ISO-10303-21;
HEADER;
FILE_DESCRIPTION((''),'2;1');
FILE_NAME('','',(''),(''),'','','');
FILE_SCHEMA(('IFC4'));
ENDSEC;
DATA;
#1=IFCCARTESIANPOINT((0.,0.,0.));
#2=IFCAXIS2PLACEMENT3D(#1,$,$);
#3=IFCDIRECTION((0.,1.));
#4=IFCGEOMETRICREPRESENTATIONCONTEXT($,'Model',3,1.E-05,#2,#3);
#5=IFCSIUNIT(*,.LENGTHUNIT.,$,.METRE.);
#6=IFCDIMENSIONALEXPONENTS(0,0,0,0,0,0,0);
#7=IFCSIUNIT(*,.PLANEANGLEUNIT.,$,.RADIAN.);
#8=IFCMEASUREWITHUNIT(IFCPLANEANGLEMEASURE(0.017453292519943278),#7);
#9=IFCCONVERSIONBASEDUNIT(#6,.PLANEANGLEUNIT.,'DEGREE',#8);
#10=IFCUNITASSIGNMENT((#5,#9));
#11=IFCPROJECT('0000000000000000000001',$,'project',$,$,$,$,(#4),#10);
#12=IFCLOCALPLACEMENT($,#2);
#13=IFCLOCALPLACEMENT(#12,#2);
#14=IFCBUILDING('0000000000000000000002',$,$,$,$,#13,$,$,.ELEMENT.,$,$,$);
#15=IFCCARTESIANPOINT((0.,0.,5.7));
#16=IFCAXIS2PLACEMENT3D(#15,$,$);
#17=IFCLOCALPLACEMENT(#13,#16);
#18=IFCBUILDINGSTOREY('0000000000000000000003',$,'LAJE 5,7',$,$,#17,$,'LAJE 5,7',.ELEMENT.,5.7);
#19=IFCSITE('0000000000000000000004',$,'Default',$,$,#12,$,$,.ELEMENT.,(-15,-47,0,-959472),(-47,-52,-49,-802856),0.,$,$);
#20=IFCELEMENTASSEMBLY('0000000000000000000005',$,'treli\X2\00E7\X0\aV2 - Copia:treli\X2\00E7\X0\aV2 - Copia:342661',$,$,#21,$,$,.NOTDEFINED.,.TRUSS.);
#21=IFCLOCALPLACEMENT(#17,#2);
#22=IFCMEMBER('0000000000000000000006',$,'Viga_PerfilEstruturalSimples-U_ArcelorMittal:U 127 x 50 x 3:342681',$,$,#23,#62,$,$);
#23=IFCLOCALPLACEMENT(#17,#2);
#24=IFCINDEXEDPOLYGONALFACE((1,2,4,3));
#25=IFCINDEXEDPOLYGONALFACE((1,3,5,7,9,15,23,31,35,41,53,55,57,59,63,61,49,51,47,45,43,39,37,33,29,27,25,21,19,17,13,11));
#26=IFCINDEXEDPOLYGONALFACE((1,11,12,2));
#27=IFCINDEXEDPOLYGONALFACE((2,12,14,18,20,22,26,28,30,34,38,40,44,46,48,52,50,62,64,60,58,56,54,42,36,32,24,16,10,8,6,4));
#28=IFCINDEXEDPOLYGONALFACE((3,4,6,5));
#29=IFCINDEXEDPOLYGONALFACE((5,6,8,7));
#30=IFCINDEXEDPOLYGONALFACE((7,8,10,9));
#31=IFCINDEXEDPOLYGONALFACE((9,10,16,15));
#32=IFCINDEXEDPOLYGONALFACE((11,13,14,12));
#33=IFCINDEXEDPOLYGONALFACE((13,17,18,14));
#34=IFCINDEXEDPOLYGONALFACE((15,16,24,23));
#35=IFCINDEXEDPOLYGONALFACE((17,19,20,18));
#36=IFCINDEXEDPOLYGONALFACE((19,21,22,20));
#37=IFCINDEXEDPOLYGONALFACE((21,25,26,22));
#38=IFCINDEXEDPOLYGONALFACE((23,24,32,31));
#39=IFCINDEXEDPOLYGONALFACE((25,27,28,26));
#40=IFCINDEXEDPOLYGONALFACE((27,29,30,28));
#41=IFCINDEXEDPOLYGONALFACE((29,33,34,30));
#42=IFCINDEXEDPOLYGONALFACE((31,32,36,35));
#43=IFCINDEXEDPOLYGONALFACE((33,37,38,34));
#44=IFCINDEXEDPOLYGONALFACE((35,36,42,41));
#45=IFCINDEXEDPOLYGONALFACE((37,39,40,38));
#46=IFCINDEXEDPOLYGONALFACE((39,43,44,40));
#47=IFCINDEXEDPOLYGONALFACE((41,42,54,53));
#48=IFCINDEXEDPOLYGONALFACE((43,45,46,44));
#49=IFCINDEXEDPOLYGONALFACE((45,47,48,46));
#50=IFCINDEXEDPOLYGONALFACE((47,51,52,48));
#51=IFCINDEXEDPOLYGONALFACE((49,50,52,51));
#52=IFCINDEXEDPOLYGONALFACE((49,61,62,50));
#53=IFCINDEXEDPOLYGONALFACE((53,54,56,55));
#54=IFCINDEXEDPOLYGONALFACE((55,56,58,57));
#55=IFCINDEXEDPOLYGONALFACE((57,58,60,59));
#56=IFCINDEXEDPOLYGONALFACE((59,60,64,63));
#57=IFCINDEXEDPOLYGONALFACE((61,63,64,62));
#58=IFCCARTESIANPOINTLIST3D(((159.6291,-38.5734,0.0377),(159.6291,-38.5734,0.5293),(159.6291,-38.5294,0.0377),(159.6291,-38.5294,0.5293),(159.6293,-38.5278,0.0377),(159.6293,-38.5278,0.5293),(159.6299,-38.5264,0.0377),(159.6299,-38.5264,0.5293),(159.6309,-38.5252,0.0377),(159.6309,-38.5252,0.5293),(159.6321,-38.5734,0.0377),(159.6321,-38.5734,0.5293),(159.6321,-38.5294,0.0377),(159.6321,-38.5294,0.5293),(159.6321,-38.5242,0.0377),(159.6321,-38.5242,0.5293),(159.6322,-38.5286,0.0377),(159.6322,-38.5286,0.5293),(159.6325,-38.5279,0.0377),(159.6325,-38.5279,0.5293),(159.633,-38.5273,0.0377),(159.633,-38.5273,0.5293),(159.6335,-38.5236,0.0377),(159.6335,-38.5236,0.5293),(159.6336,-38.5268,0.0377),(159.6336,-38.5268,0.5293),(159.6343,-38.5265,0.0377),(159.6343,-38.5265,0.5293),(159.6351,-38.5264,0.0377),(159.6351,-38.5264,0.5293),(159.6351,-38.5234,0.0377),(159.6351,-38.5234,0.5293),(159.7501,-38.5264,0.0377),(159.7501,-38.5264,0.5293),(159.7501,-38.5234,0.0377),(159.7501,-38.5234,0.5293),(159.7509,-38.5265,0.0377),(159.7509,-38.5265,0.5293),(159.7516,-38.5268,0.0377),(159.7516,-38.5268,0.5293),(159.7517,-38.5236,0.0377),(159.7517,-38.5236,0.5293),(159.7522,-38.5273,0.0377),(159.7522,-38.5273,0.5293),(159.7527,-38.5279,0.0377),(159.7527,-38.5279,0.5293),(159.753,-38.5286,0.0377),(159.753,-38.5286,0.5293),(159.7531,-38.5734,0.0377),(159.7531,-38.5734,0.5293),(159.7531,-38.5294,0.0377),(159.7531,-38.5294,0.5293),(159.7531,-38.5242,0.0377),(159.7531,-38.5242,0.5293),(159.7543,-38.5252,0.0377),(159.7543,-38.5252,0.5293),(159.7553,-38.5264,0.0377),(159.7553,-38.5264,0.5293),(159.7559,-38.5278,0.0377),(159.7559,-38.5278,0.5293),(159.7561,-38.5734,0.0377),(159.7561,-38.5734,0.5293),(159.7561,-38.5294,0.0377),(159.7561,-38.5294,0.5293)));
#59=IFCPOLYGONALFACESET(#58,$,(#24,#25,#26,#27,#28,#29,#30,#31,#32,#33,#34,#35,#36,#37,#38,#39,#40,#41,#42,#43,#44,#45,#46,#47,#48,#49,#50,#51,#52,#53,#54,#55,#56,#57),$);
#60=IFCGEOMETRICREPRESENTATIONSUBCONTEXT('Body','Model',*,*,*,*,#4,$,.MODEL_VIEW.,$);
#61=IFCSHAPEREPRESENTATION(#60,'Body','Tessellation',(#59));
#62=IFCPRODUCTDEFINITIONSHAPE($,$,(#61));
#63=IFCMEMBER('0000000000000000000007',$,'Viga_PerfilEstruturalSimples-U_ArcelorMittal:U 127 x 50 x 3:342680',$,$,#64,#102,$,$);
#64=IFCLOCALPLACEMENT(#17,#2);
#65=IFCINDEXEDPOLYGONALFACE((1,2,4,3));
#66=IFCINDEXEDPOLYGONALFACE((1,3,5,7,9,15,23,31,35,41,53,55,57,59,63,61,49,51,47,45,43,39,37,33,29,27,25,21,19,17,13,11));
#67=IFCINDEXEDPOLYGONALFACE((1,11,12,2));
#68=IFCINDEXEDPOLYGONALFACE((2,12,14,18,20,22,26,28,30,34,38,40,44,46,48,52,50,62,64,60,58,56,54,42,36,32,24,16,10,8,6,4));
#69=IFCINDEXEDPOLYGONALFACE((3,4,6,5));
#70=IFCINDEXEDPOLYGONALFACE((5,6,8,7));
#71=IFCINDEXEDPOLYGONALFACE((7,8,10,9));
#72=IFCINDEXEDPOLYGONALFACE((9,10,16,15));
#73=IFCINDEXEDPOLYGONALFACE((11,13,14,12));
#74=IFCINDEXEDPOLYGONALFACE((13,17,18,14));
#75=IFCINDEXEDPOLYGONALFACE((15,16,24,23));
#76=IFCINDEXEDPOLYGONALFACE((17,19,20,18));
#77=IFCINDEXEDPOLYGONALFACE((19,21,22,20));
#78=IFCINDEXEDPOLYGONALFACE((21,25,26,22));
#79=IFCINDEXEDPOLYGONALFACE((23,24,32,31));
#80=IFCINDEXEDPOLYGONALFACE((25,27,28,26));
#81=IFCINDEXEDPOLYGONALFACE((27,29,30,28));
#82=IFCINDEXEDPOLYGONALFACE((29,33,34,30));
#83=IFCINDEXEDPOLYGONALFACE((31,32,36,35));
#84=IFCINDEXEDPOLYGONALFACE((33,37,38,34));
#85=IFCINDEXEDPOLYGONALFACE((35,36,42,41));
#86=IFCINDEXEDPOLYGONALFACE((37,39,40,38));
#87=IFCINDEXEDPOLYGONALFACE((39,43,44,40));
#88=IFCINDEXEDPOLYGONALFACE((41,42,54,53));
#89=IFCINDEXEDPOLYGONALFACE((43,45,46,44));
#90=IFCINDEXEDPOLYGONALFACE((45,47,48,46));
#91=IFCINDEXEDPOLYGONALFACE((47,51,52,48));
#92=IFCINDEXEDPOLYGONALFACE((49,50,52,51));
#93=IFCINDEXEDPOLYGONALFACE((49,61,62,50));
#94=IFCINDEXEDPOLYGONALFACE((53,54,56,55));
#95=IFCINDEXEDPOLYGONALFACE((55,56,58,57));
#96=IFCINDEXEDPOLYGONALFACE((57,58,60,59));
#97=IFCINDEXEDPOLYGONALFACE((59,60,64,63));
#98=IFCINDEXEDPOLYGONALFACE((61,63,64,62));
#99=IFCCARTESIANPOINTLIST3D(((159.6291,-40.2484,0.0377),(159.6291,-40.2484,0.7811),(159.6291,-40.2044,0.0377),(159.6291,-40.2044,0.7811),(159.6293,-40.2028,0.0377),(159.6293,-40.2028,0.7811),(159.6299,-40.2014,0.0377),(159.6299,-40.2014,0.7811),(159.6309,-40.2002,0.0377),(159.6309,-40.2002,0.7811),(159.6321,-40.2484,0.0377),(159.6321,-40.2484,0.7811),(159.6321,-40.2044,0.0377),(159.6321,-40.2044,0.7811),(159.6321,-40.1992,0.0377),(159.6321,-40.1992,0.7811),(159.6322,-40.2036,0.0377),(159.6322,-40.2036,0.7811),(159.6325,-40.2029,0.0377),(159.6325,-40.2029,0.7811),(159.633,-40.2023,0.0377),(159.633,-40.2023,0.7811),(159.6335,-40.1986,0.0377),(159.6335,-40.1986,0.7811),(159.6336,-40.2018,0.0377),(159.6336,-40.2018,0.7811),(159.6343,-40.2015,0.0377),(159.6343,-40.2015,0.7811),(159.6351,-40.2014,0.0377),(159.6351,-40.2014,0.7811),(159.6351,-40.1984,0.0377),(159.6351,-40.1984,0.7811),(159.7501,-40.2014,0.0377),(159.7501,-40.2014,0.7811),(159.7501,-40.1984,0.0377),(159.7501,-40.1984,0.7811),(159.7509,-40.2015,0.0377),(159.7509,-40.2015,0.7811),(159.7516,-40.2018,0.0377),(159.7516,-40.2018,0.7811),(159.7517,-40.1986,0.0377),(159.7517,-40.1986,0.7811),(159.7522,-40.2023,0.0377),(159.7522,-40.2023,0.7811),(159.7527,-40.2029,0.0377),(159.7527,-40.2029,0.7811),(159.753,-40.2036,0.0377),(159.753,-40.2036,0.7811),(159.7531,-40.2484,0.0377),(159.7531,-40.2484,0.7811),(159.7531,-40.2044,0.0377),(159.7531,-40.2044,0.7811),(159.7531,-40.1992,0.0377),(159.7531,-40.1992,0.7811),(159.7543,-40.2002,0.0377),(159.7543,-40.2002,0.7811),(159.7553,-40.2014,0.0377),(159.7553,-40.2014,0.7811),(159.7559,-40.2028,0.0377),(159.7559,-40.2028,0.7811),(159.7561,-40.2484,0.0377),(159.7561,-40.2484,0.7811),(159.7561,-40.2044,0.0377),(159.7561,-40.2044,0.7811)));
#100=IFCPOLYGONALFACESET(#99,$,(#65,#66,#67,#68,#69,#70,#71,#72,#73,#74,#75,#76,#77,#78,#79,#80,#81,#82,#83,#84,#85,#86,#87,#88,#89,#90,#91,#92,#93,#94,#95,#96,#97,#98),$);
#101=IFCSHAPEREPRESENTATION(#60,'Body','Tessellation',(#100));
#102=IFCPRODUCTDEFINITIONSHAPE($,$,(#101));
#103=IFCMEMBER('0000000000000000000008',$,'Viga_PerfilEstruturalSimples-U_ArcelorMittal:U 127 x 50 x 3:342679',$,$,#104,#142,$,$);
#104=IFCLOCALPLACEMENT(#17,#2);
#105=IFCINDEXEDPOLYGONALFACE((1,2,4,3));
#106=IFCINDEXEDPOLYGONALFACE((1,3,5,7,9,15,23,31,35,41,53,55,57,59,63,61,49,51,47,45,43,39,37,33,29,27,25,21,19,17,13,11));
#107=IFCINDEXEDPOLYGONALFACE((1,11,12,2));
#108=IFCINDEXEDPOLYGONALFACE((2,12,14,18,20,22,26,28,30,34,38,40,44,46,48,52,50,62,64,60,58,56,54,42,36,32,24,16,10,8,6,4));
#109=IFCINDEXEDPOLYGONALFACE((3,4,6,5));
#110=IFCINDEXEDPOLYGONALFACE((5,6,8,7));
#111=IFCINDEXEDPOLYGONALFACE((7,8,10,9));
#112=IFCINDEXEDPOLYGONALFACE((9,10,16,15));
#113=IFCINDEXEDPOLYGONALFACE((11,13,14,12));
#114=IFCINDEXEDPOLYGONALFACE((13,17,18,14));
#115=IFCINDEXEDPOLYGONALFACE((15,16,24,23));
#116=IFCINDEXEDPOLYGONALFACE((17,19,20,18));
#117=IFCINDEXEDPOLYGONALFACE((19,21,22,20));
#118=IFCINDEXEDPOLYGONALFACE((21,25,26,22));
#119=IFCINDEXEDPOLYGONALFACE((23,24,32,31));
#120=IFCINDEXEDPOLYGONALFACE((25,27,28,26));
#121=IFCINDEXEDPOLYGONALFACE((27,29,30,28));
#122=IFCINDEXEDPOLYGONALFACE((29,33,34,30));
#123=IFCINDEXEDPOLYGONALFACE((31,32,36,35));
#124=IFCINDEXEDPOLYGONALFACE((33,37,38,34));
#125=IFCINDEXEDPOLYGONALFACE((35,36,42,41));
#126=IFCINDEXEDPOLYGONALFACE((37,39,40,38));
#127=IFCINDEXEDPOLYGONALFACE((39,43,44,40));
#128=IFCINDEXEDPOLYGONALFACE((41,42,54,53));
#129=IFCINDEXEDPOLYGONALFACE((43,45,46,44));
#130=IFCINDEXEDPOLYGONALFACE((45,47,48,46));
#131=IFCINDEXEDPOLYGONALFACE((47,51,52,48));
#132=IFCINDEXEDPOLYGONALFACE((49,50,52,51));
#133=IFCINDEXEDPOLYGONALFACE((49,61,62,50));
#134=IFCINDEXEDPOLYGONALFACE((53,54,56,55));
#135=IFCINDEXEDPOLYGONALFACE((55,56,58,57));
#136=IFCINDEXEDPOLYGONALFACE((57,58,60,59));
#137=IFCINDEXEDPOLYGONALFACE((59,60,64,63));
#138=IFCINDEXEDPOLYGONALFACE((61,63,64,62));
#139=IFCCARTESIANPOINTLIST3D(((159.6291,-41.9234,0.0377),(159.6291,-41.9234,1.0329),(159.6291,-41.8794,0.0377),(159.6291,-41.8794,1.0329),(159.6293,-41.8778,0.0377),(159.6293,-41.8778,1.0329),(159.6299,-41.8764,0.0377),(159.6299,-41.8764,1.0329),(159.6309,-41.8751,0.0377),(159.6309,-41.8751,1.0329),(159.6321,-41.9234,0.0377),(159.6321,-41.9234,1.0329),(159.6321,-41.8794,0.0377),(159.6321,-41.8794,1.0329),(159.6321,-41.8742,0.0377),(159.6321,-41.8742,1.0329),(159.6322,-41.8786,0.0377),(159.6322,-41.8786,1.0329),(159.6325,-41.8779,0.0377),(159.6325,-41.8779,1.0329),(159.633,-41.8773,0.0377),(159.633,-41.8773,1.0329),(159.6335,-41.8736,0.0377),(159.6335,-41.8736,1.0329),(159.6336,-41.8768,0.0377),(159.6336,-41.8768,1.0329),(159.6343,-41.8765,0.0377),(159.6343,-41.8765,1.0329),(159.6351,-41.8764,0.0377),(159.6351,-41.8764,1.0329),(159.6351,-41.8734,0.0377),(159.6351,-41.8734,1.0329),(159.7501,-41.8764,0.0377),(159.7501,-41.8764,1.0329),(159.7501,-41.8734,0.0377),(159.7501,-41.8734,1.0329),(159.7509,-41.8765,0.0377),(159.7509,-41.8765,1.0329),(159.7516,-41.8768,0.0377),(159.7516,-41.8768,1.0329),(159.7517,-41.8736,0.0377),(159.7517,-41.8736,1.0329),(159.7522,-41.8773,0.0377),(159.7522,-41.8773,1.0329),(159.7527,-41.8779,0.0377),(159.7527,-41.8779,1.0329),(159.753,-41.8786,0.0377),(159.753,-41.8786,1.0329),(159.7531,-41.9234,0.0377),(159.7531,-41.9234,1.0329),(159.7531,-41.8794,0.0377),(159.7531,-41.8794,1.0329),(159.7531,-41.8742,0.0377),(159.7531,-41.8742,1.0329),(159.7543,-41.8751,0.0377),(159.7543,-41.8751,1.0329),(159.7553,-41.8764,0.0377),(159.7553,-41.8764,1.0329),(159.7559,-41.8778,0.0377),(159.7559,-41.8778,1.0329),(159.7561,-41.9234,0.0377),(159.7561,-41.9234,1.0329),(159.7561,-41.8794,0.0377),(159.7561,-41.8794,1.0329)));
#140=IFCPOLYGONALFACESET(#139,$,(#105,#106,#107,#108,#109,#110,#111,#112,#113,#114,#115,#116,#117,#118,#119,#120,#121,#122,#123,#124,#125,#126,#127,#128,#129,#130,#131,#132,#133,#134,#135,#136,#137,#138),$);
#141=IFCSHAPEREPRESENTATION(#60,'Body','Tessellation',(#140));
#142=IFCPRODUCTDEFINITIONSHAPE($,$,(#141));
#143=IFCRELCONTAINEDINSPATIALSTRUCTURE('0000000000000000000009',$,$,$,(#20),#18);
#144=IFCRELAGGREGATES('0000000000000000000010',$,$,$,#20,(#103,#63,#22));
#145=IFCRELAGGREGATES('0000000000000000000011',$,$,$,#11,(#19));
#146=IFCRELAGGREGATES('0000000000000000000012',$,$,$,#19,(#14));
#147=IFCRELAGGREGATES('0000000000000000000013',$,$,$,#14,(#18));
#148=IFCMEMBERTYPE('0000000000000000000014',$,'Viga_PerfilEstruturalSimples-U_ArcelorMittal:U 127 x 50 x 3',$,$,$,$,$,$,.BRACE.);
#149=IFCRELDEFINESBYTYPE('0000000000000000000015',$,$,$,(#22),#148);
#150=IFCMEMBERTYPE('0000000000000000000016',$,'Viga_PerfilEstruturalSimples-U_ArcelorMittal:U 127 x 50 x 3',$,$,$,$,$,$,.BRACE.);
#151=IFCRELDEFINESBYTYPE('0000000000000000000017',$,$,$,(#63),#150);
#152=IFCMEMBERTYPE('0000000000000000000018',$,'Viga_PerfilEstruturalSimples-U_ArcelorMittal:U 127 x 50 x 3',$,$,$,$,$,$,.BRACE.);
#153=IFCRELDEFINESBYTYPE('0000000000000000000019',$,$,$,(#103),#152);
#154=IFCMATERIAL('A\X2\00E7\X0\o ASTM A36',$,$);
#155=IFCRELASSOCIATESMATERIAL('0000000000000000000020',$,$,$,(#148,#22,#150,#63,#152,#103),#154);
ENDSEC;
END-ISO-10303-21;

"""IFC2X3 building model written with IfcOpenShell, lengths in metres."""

from ifc_helpers import new_model, entity, si_unit, converted_unit, direction, frame, frame_2d, origin, place, context, subcontext, project, spatial, polyline, circle_curve, parameter, trimmed, segment, composite_curve, outline, extrude, source, transform, mapped, material, type_object, type_shapes, element, aggregate, save


model = new_model("IFC2X3")

# Units and contexts
model_context = context("Model", 3, precision=1e-05, world=origin(), true_north=direction((0.0, 1.0)))
body_context = subcontext(model_context, "Body", "Model", "MODEL_VIEW")
ifc_project = project(units=[si_unit("LENGTHUNIT", "METRE"), converted_unit("PLANEANGLEUNIT", "DEGREE", entity("IfcPlaneAngleMeasure", 0.017453292519943278), si_unit("PLANEANGLEUNIT", "RADIAN"), dimensions=[0, 0, 0, 0, 0, 0, 0])], contexts=[model_context])

# Site, building, storey
site_placement = place(None, origin())
site = spatial("IfcSite", under=ifc_project, at=site_placement, Name="Default", CompositionType="ELEMENT", RefLatitude=(-15, -47, 0, -959472), RefLongitude=(-47, -52, -49, -802856), RefElevation=0.0)
building_placement = place(site_placement, origin())
building = spatial("IfcBuilding", under=site, at=building_placement, CompositionType="ELEMENT")
storey_placement = place(building_placement, frame((0.0, 0.0, 5.7)))
storey = spatial("IfcBuildingStorey", under=building, at=storey_placement, Name="LAJE 5,7", LongName="LAJE 5,7", CompositionType="ELEMENT", Elevation=5.7)

# Element assembly
ifc_material = material(Name="Aço ASTM A36")
assembly_1_placement = place(storey_placement, origin())
assembly_1 = element("IfcElementAssembly", 1, at=assembly_1_placement, inside=storey, Name="treliçaV2 - Copia:treliçaV2 - Copia:342661", AssemblyPlace="NOTDEFINED", PredefinedType="TRUSS")

# Members
member_type_1 = type_object("IfcMemberType", Name="Viga_PerfilEstruturalSimples-U_ArcelorMittal:U 127 x 50 x 3", PredefinedType="BRACE", material=ifc_material)
shared_shape_1 = source(origin(), body_context, "Body", "SweptSolid", [
    extrude(outline(composite_curve([segment(polyline([(-0.0575, -0.0192), (0.0575, -0.0192)]), True, "CONTINUOUS"), segment(trimmed(circle_curve(frame_2d((0.0575, -0.0132), x_axis=(0.0, 1.0)), 0.006), [parameter(180.0)], [parameter(270.0)], True, "PARAMETER"), True, "CONTINUOUS"), segment(polyline([(0.0635, -0.0132), (0.0635, 0.0308)]), True, "CONTINUOUS"), segment(polyline([(0.0635, 0.0308), (0.0605, 0.0308)]), True, "CONTINUOUS"), segment(polyline([(0.0605, 0.0308), (0.0605, -0.0132)]), True, "CONTINUOUS"), segment(trimmed(circle_curve(frame_2d((0.0575, -0.0132), x_axis=(0.0, 1.0)), 0.003), [parameter(180.0)], [parameter(270.0)], True, "PARAMETER"), False, "CONTINUOUS"), segment(polyline([(0.0575, -0.0162), (-0.0575, -0.0162)]), True, "CONTINUOUS"), segment(trimmed(circle_curve(frame_2d((-0.0575, -0.0132), x_axis=(0.0, 1.0)), 0.003), [parameter(90.0)], [parameter(180.0)], True, "PARAMETER"), False, "CONTINUOUS"), segment(polyline([(-0.0605, -0.0132), (-0.0605, 0.0308)]), True, "CONTINUOUS"), segment(polyline([(-0.0605, 0.0308), (-0.0635, 0.0308)]), True, "CONTINUOUS"), segment(polyline([(-0.0635, 0.0308), (-0.0635, -0.0132)]), True, "CONTINUOUS"), segment(trimmed(circle_curve(frame_2d((-0.0575, -0.0132), x_axis=(0.0, 1.0)), 0.006), [parameter(90.0)], [parameter(180.0)], True, "PARAMETER"), True, "CONTINUOUS")], self_intersect=False)), frame((-0.2478, -0.0058, 0.0), z_axis=(1.0, 0.0, 0.0), x_axis=(0.0, 0.0, -1.0)), (0.0, 0.0, 1.0), 0.4916),
])
type_shapes(member_type_1, [shared_shape_1])
member_1_placement = place(assembly_1_placement, frame((159.6926, -38.5484, 0.2855), z_axis=(1.0, 0.0, 0.0), x_axis=(0.0, 0.0, 1.0)))
member_1 = element("IfcMember", 2, at=member_1_placement, type_object=member_type_1, material=ifc_material, Name="Viga_PerfilEstruturalSimples-U_ArcelorMittal:U 127 x 50 x 3:342681", context=body_context, shape_type="MappedRepresentation", body=[
    mapped(shared_shape_1, transform((0.0, 0.0, 0.0), scale=1.0)),
])
member_type_2 = type_object("IfcMemberType", Name="Viga_PerfilEstruturalSimples-U_ArcelorMittal:U 127 x 50 x 3", PredefinedType="BRACE", material=ifc_material)
shared_shape_2 = source(origin(), body_context, "Body", "SweptSolid", [
    extrude(outline(composite_curve([segment(polyline([(-0.0575, -0.0192), (0.0575, -0.0192)]), True, "CONTINUOUS"), segment(trimmed(circle_curve(frame_2d((0.0575, -0.0132), x_axis=(0.0, 1.0)), 0.006), [parameter(180.0)], [parameter(270.0)], True, "PARAMETER"), True, "CONTINUOUS"), segment(polyline([(0.0635, -0.0132), (0.0635, 0.0308)]), True, "CONTINUOUS"), segment(polyline([(0.0635, 0.0308), (0.0605, 0.0308)]), True, "CONTINUOUS"), segment(polyline([(0.0605, 0.0308), (0.0605, -0.0132)]), True, "CONTINUOUS"), segment(trimmed(circle_curve(frame_2d((0.0575, -0.0132), x_axis=(0.0, 1.0)), 0.003), [parameter(180.0)], [parameter(270.0)], True, "PARAMETER"), False, "CONTINUOUS"), segment(polyline([(0.0575, -0.0162), (-0.0575, -0.0162)]), True, "CONTINUOUS"), segment(trimmed(circle_curve(frame_2d((-0.0575, -0.0132), x_axis=(0.0, 1.0)), 0.003), [parameter(90.0)], [parameter(180.0)], True, "PARAMETER"), False, "CONTINUOUS"), segment(polyline([(-0.0605, -0.0132), (-0.0605, 0.0308)]), True, "CONTINUOUS"), segment(polyline([(-0.0605, 0.0308), (-0.0635, 0.0308)]), True, "CONTINUOUS"), segment(polyline([(-0.0635, 0.0308), (-0.0635, -0.0132)]), True, "CONTINUOUS"), segment(trimmed(circle_curve(frame_2d((-0.0575, -0.0132), x_axis=(0.0, 1.0)), 0.006), [parameter(90.0)], [parameter(180.0)], True, "PARAMETER"), True, "CONTINUOUS")], self_intersect=False)), frame((-0.3737, -0.0058, 0.0), z_axis=(1.0, 0.0, 0.0), x_axis=(0.0, 0.0, -1.0)), (0.0, 0.0, 1.0), 0.7434),
])
type_shapes(member_type_2, [shared_shape_2])
member_2_placement = place(assembly_1_placement, frame((159.6926, -40.2234, 0.4114), z_axis=(1.0, 0.0, 0.0), x_axis=(0.0, 0.0, 1.0)))
member_2 = element("IfcMember", 3, at=member_2_placement, type_object=member_type_2, material=ifc_material, Name="Viga_PerfilEstruturalSimples-U_ArcelorMittal:U 127 x 50 x 3:342680", context=body_context, shape_type="MappedRepresentation", body=[
    mapped(shared_shape_2, transform((0.0, 0.0, 0.0), scale=1.0)),
])
member_type_3 = type_object("IfcMemberType", Name="Viga_PerfilEstruturalSimples-U_ArcelorMittal:U 127 x 50 x 3", PredefinedType="BRACE", material=ifc_material)
shared_shape_3 = source(origin(), body_context, "Body", "SweptSolid", [
    extrude(outline(composite_curve([segment(polyline([(-0.0575, -0.0192), (0.0575, -0.0192)]), True, "CONTINUOUS"), segment(trimmed(circle_curve(frame_2d((0.0575, -0.0132), x_axis=(0.0, 1.0)), 0.006), [parameter(180.0)], [parameter(270.0)], True, "PARAMETER"), True, "CONTINUOUS"), segment(polyline([(0.0635, -0.0132), (0.0635, 0.0308)]), True, "CONTINUOUS"), segment(polyline([(0.0635, 0.0308), (0.0605, 0.0308)]), True, "CONTINUOUS"), segment(polyline([(0.0605, 0.0308), (0.0605, -0.0132)]), True, "CONTINUOUS"), segment(trimmed(circle_curve(frame_2d((0.0575, -0.0132), x_axis=(0.0, 1.0)), 0.003), [parameter(180.0)], [parameter(270.0)], True, "PARAMETER"), False, "CONTINUOUS"), segment(polyline([(0.0575, -0.0162), (-0.0575, -0.0162)]), True, "CONTINUOUS"), segment(trimmed(circle_curve(frame_2d((-0.0575, -0.0132), x_axis=(0.0, 1.0)), 0.003), [parameter(90.0)], [parameter(180.0)], True, "PARAMETER"), False, "CONTINUOUS"), segment(polyline([(-0.0605, -0.0132), (-0.0605, 0.0308)]), True, "CONTINUOUS"), segment(polyline([(-0.0605, 0.0308), (-0.0635, 0.0308)]), True, "CONTINUOUS"), segment(polyline([(-0.0635, 0.0308), (-0.0635, -0.0132)]), True, "CONTINUOUS"), segment(trimmed(circle_curve(frame_2d((-0.0575, -0.0132), x_axis=(0.0, 1.0)), 0.006), [parameter(90.0)], [parameter(180.0)], True, "PARAMETER"), True, "CONTINUOUS")], self_intersect=False)), frame((-0.4996, -0.0058, 0.0), z_axis=(1.0, 0.0, 0.0), x_axis=(0.0, 0.0, -1.0)), (0.0, 0.0, 1.0), 0.9952),
])
type_shapes(member_type_3, [shared_shape_3])
member_3_placement = place(assembly_1_placement, frame((159.6926, -41.8984, 0.5373), z_axis=(1.0, 0.0, 0.0), x_axis=(0.0, 0.0, 1.0)))
member_3 = element("IfcMember", 4, at=member_3_placement, type_object=member_type_3, material=ifc_material, Name="Viga_PerfilEstruturalSimples-U_ArcelorMittal:U 127 x 50 x 3:342679", context=body_context, shape_type="MappedRepresentation", body=[
    mapped(shared_shape_3, transform((0.0, 0.0, 0.0), scale=1.0)),
])
aggregate(assembly_1, [member_3, member_2, member_1])

save(model, "model.ifc")
